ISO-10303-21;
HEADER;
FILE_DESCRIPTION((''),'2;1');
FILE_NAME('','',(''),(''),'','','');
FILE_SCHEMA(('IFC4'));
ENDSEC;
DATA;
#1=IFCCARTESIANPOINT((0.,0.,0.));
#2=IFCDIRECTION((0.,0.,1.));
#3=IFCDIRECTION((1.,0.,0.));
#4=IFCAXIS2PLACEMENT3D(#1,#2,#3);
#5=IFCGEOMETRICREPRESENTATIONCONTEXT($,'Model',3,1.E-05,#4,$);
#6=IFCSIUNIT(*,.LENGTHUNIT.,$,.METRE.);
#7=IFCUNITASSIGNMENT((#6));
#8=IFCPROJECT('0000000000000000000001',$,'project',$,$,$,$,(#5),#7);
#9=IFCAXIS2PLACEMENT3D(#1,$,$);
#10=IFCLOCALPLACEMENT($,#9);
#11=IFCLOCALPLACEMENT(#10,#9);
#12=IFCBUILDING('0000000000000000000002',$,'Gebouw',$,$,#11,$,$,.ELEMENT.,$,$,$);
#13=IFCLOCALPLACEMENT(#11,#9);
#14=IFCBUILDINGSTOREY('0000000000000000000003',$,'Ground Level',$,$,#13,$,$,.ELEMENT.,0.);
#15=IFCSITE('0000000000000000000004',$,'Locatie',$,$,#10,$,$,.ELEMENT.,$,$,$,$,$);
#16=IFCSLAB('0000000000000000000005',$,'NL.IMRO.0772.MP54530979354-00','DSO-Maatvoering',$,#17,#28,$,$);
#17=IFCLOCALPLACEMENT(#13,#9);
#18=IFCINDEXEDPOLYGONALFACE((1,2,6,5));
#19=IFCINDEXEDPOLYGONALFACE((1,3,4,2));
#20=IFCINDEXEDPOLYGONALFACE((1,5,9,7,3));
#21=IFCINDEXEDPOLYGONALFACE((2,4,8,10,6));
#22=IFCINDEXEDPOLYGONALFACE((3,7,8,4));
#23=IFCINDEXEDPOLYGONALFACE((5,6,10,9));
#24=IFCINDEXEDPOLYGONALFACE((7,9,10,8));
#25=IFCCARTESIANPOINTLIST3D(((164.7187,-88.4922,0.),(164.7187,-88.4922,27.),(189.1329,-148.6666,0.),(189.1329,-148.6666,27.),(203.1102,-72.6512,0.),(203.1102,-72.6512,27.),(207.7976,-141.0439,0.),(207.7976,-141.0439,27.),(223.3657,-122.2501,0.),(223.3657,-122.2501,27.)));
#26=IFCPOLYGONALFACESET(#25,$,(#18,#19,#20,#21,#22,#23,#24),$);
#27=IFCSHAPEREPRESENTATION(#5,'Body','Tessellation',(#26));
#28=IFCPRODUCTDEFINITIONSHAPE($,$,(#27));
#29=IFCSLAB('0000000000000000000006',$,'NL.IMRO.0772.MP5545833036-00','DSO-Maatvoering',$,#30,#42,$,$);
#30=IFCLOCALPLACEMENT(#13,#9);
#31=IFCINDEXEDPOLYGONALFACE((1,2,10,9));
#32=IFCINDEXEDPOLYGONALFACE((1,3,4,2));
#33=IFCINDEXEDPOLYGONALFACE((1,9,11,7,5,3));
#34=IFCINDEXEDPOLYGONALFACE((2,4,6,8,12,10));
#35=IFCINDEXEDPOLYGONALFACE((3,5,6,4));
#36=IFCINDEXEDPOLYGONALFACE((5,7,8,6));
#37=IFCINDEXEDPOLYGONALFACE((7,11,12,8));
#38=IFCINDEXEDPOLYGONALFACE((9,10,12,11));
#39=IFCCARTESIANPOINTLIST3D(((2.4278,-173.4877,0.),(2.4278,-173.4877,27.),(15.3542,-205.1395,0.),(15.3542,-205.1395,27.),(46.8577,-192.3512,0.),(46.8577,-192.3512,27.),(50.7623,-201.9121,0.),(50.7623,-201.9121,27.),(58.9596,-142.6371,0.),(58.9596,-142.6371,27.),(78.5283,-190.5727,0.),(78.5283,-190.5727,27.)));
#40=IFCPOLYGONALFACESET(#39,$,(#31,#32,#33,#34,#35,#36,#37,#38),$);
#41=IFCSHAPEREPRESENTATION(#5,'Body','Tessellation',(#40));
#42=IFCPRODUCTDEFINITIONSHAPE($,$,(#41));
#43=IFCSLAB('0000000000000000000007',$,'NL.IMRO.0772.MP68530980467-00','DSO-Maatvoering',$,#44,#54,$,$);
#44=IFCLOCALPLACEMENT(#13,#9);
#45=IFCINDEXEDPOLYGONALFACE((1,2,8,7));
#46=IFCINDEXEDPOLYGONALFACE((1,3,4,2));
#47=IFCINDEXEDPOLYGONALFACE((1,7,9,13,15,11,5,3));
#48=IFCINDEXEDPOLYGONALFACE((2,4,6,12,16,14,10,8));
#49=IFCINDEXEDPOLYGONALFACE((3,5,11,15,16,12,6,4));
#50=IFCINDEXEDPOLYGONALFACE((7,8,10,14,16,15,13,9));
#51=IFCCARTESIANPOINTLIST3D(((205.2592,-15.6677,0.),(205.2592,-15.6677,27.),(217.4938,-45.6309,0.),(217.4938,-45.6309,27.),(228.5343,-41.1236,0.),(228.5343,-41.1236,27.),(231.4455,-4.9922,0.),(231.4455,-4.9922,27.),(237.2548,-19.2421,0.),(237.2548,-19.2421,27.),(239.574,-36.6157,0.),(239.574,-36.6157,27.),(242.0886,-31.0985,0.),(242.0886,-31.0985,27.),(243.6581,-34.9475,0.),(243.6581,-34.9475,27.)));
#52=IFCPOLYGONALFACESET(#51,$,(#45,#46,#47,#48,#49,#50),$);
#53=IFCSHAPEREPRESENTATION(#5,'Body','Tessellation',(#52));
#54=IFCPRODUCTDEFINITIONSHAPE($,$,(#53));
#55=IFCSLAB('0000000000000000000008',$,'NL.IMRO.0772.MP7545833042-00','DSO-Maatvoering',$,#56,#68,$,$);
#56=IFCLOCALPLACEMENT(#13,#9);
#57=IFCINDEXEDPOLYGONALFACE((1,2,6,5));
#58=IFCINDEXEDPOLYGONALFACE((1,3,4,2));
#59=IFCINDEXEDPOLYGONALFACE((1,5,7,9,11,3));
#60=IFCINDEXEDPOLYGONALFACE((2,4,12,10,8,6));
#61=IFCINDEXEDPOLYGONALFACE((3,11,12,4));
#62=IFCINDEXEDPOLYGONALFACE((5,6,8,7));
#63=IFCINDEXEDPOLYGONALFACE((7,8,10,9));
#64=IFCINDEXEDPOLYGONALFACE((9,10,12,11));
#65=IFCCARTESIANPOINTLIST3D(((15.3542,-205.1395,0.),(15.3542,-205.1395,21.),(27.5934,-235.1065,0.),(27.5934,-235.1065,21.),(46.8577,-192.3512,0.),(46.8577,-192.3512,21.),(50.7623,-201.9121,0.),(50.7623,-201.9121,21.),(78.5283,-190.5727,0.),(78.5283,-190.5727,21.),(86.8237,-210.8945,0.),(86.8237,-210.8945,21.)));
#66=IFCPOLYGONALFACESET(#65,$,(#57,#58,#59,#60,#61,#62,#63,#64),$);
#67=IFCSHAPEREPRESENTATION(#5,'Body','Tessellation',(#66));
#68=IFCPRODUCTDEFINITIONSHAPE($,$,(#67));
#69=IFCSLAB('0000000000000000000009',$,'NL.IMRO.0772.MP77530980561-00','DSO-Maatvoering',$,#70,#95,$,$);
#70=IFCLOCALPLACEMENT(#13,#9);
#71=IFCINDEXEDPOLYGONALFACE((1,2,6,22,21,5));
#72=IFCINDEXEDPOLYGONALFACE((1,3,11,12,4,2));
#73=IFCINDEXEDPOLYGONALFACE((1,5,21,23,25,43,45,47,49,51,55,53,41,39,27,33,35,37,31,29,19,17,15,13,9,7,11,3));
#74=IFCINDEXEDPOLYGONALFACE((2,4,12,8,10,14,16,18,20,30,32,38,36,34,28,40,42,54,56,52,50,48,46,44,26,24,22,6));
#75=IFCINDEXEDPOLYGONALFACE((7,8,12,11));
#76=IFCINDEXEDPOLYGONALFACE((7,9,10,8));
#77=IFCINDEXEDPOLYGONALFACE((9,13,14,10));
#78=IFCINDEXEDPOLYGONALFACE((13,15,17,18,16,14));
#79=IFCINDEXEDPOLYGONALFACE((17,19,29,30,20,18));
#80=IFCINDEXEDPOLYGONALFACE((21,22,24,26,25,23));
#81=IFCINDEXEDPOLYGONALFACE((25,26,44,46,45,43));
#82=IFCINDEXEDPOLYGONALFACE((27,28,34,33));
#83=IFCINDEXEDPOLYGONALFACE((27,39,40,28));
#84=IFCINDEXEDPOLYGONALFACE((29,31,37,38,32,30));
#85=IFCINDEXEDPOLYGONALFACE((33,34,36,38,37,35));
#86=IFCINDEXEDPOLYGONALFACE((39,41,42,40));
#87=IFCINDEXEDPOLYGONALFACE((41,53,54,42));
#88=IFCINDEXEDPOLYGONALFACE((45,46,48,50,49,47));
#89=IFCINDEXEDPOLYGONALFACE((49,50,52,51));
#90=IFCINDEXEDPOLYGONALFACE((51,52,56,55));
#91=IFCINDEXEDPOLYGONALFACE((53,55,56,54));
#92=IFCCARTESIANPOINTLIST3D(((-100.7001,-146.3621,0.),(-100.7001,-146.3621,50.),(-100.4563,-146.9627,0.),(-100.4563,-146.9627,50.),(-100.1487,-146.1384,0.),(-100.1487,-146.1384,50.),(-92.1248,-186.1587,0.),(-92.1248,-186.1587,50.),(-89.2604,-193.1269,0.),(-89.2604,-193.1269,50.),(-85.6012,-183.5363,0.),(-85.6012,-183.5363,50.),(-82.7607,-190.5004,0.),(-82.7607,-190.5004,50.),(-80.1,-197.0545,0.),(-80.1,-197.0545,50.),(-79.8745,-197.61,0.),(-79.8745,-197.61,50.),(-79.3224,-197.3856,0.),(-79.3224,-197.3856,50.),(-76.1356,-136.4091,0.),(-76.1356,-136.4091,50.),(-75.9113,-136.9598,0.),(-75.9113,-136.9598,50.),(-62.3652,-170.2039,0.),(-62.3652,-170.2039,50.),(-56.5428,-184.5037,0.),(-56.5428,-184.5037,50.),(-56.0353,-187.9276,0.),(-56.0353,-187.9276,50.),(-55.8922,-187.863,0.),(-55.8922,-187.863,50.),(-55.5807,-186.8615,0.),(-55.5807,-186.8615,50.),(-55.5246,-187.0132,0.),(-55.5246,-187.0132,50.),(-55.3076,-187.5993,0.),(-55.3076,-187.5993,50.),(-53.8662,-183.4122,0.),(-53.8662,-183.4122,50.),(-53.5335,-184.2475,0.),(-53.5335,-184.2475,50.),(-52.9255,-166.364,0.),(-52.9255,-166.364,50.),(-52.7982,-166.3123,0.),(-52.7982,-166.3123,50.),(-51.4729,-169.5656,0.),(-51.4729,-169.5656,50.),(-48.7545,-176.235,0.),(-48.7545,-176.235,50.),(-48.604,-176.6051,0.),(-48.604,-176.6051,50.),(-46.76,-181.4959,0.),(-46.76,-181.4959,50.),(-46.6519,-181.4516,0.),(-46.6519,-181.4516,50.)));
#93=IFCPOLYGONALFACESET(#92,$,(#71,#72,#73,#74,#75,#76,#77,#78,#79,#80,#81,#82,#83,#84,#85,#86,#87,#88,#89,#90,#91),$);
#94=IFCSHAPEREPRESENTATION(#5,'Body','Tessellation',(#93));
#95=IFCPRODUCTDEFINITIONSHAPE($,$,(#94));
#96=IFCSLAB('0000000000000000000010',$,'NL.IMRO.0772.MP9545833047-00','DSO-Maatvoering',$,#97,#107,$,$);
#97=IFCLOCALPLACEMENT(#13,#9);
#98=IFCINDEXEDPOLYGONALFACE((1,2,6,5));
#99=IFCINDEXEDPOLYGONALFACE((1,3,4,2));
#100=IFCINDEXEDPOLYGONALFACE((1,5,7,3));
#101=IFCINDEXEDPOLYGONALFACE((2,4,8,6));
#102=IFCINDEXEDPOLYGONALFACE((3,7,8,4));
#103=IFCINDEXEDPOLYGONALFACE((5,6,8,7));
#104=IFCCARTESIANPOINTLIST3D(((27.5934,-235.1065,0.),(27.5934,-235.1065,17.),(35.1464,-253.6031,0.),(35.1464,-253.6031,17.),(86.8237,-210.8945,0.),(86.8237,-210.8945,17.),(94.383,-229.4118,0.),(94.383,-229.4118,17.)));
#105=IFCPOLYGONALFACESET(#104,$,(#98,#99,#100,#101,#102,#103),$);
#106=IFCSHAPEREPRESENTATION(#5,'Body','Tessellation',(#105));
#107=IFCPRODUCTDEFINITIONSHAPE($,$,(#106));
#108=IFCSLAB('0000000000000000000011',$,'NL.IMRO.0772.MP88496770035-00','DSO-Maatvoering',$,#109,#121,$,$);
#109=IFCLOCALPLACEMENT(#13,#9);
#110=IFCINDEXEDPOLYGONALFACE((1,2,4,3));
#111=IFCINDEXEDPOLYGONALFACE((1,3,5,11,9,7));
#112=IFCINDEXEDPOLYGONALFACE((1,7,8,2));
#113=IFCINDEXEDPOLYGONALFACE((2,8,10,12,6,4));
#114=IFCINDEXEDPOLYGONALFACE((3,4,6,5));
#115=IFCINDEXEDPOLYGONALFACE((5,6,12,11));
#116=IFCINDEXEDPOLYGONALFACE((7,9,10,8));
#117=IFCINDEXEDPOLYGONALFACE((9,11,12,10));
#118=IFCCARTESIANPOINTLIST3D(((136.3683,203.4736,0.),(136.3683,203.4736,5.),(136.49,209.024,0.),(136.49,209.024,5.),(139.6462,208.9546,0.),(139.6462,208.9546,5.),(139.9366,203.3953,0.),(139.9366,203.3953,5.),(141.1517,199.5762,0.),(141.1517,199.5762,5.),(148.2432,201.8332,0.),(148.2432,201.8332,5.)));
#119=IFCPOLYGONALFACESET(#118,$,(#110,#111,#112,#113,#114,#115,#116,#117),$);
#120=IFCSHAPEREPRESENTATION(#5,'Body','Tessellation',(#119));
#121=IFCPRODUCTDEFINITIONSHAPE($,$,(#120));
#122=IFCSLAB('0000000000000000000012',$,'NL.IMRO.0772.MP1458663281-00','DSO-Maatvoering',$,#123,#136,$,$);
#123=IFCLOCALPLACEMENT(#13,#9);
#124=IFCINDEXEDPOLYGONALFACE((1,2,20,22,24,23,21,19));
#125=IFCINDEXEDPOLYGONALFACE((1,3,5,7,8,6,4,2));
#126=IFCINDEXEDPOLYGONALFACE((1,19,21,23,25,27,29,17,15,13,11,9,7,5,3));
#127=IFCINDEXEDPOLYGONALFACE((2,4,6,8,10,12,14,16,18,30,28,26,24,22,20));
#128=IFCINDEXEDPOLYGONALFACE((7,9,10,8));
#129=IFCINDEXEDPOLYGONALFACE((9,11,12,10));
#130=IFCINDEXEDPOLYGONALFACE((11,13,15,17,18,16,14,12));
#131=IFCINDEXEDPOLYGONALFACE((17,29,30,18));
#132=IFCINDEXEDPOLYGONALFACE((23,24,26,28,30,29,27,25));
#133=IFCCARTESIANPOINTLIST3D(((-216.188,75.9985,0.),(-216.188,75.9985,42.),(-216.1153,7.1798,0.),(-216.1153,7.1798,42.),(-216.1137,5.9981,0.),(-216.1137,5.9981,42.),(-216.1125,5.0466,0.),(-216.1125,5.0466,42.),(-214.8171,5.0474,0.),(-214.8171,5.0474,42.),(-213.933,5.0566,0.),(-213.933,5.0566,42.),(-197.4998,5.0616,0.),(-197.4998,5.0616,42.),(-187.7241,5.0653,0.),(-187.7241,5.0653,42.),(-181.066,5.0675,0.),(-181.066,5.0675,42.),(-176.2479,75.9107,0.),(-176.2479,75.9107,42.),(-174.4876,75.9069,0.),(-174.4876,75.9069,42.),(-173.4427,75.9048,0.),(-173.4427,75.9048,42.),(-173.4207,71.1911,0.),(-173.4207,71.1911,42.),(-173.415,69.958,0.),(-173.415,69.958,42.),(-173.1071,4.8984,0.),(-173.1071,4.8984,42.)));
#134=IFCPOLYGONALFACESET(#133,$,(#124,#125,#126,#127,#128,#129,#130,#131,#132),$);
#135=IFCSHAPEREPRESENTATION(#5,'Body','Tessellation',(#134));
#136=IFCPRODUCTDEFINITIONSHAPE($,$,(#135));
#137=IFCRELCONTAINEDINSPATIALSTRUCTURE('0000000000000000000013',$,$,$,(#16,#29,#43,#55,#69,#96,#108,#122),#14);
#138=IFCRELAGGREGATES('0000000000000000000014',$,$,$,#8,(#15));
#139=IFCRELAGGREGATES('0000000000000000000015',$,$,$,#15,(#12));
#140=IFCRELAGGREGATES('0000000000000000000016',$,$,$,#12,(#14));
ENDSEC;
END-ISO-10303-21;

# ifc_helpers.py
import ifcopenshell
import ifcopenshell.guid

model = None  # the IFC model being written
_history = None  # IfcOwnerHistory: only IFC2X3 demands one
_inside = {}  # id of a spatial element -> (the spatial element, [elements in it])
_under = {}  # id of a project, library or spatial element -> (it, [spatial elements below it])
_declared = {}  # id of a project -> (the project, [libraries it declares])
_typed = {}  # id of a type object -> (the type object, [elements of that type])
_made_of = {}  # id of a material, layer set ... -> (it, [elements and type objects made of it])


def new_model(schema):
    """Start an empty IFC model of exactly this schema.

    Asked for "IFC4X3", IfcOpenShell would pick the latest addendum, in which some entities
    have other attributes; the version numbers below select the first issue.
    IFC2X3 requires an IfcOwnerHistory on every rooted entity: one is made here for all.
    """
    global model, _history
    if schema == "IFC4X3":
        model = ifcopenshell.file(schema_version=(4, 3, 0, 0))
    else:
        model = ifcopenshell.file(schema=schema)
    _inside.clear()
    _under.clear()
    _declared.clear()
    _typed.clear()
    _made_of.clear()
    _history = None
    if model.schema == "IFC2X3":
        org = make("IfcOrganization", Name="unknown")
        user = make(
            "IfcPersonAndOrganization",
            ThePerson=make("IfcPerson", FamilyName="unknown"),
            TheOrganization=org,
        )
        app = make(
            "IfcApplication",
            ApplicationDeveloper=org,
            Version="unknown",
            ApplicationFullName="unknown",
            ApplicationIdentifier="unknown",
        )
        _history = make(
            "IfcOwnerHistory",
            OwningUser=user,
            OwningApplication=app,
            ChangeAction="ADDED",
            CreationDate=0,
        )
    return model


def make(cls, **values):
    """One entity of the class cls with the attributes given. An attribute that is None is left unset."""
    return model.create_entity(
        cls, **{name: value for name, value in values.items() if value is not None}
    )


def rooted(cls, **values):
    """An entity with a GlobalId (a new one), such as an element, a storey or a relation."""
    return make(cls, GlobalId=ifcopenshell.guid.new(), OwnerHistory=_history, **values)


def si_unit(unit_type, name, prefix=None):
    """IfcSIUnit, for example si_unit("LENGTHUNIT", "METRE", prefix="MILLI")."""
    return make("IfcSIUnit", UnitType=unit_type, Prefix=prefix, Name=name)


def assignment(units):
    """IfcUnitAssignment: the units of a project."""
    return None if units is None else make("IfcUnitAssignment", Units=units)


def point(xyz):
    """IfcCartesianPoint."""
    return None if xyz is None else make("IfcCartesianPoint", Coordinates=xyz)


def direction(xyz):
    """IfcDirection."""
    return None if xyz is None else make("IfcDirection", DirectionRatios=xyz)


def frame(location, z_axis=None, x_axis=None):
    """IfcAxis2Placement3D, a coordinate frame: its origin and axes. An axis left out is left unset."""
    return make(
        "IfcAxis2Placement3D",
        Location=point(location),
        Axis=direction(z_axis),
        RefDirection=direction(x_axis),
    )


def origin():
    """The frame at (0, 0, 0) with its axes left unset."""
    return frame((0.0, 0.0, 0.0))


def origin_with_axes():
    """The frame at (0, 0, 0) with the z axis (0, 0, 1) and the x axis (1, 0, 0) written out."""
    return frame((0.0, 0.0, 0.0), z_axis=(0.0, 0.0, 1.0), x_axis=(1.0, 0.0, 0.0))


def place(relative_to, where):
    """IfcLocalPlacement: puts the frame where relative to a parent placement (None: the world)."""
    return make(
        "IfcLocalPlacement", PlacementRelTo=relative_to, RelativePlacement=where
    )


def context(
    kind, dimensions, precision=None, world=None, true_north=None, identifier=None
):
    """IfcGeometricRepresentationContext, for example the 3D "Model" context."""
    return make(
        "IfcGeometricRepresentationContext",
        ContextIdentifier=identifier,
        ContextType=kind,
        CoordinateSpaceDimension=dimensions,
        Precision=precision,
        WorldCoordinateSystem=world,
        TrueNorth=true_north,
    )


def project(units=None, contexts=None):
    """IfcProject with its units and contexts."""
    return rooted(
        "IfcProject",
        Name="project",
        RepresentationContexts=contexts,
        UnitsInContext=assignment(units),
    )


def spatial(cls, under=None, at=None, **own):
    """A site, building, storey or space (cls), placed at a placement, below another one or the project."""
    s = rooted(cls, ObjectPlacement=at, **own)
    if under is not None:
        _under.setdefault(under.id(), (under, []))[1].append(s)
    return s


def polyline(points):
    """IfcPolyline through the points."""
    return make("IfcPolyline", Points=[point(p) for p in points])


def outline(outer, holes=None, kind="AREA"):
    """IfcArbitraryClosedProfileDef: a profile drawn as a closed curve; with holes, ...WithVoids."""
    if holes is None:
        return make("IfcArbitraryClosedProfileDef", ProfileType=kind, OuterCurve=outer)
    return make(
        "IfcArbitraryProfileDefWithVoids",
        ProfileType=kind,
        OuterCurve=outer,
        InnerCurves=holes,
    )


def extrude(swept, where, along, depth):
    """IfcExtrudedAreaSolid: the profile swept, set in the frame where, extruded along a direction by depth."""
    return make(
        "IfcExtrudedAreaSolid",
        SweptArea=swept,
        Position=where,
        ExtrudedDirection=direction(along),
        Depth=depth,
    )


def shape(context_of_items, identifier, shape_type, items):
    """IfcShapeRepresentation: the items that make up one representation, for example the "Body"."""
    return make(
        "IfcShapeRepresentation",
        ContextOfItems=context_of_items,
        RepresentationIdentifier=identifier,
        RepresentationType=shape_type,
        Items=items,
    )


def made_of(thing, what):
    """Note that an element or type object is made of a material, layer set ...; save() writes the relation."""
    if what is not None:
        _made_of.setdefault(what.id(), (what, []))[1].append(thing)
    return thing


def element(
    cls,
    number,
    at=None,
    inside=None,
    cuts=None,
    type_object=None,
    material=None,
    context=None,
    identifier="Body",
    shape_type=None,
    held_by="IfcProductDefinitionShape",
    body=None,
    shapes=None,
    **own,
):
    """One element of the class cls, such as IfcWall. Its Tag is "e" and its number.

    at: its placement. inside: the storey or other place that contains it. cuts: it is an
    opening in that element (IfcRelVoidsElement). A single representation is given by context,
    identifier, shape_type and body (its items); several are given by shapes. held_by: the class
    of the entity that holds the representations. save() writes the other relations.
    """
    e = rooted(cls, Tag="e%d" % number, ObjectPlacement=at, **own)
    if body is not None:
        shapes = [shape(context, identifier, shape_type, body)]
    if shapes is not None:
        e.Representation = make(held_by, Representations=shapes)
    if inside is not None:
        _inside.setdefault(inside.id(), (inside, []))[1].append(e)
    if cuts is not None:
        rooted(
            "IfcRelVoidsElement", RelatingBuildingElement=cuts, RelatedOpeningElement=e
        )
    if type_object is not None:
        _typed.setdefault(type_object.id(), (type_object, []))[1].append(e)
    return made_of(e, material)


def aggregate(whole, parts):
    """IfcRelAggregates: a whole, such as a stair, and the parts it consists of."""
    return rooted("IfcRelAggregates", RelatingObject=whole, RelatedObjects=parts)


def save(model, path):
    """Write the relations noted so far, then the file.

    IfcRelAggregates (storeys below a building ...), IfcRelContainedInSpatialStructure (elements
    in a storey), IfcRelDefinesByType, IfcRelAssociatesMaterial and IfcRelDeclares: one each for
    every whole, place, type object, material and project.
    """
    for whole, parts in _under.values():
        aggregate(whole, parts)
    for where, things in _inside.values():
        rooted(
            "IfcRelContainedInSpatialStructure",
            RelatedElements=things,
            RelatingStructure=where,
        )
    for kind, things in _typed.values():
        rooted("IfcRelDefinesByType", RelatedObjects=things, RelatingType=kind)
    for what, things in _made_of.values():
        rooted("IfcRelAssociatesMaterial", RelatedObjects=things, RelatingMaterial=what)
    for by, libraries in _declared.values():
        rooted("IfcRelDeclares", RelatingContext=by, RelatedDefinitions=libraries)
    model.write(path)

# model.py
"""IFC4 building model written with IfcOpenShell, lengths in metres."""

from ifc_helpers import new_model, si_unit, origin, origin_with_axes, place, context, project, spatial, polyline, outline, extrude, element, save


model = new_model("IFC4")

# Units and contexts
model_context = context("Model", 3, precision=1e-05, world=origin_with_axes())
ifc_project = project(units=[si_unit("LENGTHUNIT", "METRE")], contexts=[model_context])

# Site, building, storey
site_placement = place(None, origin())
site = spatial("IfcSite", under=ifc_project, at=site_placement, Name="Locatie", CompositionType="ELEMENT")
building_placement = place(site_placement, origin())
building = spatial("IfcBuilding", under=site, at=building_placement, Name="Gebouw", CompositionType="ELEMENT")
storey_placement = place(building_placement, origin())
storey = spatial("IfcBuildingStorey", under=building, at=storey_placement, Name="Ground Level", CompositionType="ELEMENT", Elevation=0.0)

# Slabs
slab_1_placement = place(storey_placement, origin())
element("IfcSlab", 1, at=slab_1_placement, inside=storey, Name="NL.IMRO.0772.MP54530979354-00", Description="DSO-Maatvoering", context=model_context, shape_type="SweptSolid", body=[
    extrude(outline(polyline([(189.1329, -148.6666), (164.7187, -88.4922), (203.1102, -72.6512), (223.3657, -122.2501), (207.7976, -141.0439), (189.1329, -148.6666)])), origin_with_axes(), (0.0, 0.0, 1.0), 27.0),
])
slab_2_placement = place(storey_placement, origin())
element("IfcSlab", 2, at=slab_2_placement, inside=storey, Name="NL.IMRO.0772.MP5545833036-00", Description="DSO-Maatvoering", context=model_context, shape_type="SweptSolid", body=[
    extrude(outline(polyline([(78.5283, -190.5727), (50.7623, -201.9121), (46.8577, -192.3512), (15.3542, -205.1395), (2.4278, -173.4877), (58.9596, -142.6371), (78.5283, -190.5727)])), origin_with_axes(), (0.0, 0.0, 1.0), 27.0),
])
slab_3_placement = place(storey_placement, origin())
element("IfcSlab", 3, at=slab_3_placement, inside=storey, Name="NL.IMRO.0772.MP68530980467-00", Description="DSO-Maatvoering", context=model_context, shape_type="SweptSolid", body=[
    extrude(outline(polyline([(243.6581, -34.9475), (239.574, -36.6157), (228.5343, -41.1236), (217.4938, -45.6309), (205.2592, -15.6677), (231.4455, -4.9922), (237.2548, -19.2421), (242.0886, -31.0985), (243.6581, -34.9475)])), origin_with_axes(), (0.0, 0.0, 1.0), 27.0),
])
slab_4_placement = place(storey_placement, origin())
element("IfcSlab", 4, at=slab_4_placement, inside=storey, Name="NL.IMRO.0772.MP7545833042-00", Description="DSO-Maatvoering", context=model_context, shape_type="SweptSolid", body=[
    extrude(outline(polyline([(78.5283, -190.5727), (86.8237, -210.8945), (27.5934, -235.1065), (15.3542, -205.1395), (46.8577, -192.3512), (50.7623, -201.9121), (78.5283, -190.5727)])), origin_with_axes(), (0.0, 0.0, 1.0), 21.0),
])
slab_5_placement = place(storey_placement, origin())
element("IfcSlab", 5, at=slab_5_placement, inside=storey, Name="NL.IMRO.0772.MP77530980561-00", Description="DSO-Maatvoering", context=model_context, shape_type="SweptSolid", body=[
    extrude(outline(polyline([(-52.7982, -166.3123), (-51.4729, -169.5656), (-48.7545, -176.235), (-48.604, -176.6051), (-46.6519, -181.4516), (-46.76, -181.4959), (-53.5335, -184.2475), (-53.8662, -183.4122), (-56.5428, -184.5037), (-55.5807, -186.8615), (-55.5246, -187.0132), (-55.3076, -187.5993), (-55.8922, -187.863), (-56.0353, -187.9276), (-79.3224, -197.3856), (-79.8745, -197.61), (-80.1, -197.0545), (-82.7607, -190.5004), (-89.2604, -193.1269), (-92.1248, -186.1587), (-85.6012, -183.5363), (-100.4563, -146.9627), (-100.7001, -146.3621), (-100.1487, -146.1384), (-76.1356, -136.4091), (-75.9113, -136.9598), (-62.3652, -170.2039), (-52.9255, -166.364), (-52.7982, -166.3123)])), origin_with_axes(), (0.0, 0.0, 1.0), 50.0),
])
slab_6_placement = place(storey_placement, origin())
element("IfcSlab", 6, at=slab_6_placement, inside=storey, Name="NL.IMRO.0772.MP9545833047-00", Description="DSO-Maatvoering", context=model_context, shape_type="SweptSolid", body=[
    extrude(outline(polyline([(86.8237, -210.8945), (94.383, -229.4118), (35.1464, -253.6031), (27.5934, -235.1065), (86.8237, -210.8945)])), origin_with_axes(), (0.0, 0.0, 1.0), 17.0),
])
slab_7_placement = place(storey_placement, origin())
element("IfcSlab", 7, at=slab_7_placement, inside=storey, Name="NL.IMRO.0772.MP88496770035-00", Description="DSO-Maatvoering", context=model_context, shape_type="SweptSolid", body=[
    extrude(outline(polyline([(141.1517, 199.5762), (139.9366, 203.3953), (136.3683, 203.4736), (136.49, 209.024), (139.6462, 208.9546), (148.2432, 201.8332), (141.1517, 199.5762)])), origin_with_axes(), (0.0, 0.0, 1.0), 5.0),
])
slab_8_placement = place(storey_placement, origin())
element("IfcSlab", 8, at=slab_8_placement, inside=storey, Name="NL.IMRO.0772.MP1458663281-00", Description="DSO-Maatvoering", context=model_context, shape_type="SweptSolid", body=[
    extrude(outline(polyline([(-187.7241, 5.0653), (-197.4998, 5.0616), (-213.933, 5.0566), (-214.8171, 5.0474), (-216.1125, 5.0466), (-216.1137, 5.9981), (-216.1153, 7.1798), (-216.188, 75.9985), (-176.2479, 75.9107), (-174.4876, 75.9069), (-173.4427, 75.9048), (-173.4207, 71.1911), (-173.415, 69.958), (-173.1071, 4.8984), (-181.066, 5.0675), (-187.7241, 5.0653)])), origin_with_axes(), (0.0, 0.0, 1.0), 42.0),
])

save(model, "model.ifc")
